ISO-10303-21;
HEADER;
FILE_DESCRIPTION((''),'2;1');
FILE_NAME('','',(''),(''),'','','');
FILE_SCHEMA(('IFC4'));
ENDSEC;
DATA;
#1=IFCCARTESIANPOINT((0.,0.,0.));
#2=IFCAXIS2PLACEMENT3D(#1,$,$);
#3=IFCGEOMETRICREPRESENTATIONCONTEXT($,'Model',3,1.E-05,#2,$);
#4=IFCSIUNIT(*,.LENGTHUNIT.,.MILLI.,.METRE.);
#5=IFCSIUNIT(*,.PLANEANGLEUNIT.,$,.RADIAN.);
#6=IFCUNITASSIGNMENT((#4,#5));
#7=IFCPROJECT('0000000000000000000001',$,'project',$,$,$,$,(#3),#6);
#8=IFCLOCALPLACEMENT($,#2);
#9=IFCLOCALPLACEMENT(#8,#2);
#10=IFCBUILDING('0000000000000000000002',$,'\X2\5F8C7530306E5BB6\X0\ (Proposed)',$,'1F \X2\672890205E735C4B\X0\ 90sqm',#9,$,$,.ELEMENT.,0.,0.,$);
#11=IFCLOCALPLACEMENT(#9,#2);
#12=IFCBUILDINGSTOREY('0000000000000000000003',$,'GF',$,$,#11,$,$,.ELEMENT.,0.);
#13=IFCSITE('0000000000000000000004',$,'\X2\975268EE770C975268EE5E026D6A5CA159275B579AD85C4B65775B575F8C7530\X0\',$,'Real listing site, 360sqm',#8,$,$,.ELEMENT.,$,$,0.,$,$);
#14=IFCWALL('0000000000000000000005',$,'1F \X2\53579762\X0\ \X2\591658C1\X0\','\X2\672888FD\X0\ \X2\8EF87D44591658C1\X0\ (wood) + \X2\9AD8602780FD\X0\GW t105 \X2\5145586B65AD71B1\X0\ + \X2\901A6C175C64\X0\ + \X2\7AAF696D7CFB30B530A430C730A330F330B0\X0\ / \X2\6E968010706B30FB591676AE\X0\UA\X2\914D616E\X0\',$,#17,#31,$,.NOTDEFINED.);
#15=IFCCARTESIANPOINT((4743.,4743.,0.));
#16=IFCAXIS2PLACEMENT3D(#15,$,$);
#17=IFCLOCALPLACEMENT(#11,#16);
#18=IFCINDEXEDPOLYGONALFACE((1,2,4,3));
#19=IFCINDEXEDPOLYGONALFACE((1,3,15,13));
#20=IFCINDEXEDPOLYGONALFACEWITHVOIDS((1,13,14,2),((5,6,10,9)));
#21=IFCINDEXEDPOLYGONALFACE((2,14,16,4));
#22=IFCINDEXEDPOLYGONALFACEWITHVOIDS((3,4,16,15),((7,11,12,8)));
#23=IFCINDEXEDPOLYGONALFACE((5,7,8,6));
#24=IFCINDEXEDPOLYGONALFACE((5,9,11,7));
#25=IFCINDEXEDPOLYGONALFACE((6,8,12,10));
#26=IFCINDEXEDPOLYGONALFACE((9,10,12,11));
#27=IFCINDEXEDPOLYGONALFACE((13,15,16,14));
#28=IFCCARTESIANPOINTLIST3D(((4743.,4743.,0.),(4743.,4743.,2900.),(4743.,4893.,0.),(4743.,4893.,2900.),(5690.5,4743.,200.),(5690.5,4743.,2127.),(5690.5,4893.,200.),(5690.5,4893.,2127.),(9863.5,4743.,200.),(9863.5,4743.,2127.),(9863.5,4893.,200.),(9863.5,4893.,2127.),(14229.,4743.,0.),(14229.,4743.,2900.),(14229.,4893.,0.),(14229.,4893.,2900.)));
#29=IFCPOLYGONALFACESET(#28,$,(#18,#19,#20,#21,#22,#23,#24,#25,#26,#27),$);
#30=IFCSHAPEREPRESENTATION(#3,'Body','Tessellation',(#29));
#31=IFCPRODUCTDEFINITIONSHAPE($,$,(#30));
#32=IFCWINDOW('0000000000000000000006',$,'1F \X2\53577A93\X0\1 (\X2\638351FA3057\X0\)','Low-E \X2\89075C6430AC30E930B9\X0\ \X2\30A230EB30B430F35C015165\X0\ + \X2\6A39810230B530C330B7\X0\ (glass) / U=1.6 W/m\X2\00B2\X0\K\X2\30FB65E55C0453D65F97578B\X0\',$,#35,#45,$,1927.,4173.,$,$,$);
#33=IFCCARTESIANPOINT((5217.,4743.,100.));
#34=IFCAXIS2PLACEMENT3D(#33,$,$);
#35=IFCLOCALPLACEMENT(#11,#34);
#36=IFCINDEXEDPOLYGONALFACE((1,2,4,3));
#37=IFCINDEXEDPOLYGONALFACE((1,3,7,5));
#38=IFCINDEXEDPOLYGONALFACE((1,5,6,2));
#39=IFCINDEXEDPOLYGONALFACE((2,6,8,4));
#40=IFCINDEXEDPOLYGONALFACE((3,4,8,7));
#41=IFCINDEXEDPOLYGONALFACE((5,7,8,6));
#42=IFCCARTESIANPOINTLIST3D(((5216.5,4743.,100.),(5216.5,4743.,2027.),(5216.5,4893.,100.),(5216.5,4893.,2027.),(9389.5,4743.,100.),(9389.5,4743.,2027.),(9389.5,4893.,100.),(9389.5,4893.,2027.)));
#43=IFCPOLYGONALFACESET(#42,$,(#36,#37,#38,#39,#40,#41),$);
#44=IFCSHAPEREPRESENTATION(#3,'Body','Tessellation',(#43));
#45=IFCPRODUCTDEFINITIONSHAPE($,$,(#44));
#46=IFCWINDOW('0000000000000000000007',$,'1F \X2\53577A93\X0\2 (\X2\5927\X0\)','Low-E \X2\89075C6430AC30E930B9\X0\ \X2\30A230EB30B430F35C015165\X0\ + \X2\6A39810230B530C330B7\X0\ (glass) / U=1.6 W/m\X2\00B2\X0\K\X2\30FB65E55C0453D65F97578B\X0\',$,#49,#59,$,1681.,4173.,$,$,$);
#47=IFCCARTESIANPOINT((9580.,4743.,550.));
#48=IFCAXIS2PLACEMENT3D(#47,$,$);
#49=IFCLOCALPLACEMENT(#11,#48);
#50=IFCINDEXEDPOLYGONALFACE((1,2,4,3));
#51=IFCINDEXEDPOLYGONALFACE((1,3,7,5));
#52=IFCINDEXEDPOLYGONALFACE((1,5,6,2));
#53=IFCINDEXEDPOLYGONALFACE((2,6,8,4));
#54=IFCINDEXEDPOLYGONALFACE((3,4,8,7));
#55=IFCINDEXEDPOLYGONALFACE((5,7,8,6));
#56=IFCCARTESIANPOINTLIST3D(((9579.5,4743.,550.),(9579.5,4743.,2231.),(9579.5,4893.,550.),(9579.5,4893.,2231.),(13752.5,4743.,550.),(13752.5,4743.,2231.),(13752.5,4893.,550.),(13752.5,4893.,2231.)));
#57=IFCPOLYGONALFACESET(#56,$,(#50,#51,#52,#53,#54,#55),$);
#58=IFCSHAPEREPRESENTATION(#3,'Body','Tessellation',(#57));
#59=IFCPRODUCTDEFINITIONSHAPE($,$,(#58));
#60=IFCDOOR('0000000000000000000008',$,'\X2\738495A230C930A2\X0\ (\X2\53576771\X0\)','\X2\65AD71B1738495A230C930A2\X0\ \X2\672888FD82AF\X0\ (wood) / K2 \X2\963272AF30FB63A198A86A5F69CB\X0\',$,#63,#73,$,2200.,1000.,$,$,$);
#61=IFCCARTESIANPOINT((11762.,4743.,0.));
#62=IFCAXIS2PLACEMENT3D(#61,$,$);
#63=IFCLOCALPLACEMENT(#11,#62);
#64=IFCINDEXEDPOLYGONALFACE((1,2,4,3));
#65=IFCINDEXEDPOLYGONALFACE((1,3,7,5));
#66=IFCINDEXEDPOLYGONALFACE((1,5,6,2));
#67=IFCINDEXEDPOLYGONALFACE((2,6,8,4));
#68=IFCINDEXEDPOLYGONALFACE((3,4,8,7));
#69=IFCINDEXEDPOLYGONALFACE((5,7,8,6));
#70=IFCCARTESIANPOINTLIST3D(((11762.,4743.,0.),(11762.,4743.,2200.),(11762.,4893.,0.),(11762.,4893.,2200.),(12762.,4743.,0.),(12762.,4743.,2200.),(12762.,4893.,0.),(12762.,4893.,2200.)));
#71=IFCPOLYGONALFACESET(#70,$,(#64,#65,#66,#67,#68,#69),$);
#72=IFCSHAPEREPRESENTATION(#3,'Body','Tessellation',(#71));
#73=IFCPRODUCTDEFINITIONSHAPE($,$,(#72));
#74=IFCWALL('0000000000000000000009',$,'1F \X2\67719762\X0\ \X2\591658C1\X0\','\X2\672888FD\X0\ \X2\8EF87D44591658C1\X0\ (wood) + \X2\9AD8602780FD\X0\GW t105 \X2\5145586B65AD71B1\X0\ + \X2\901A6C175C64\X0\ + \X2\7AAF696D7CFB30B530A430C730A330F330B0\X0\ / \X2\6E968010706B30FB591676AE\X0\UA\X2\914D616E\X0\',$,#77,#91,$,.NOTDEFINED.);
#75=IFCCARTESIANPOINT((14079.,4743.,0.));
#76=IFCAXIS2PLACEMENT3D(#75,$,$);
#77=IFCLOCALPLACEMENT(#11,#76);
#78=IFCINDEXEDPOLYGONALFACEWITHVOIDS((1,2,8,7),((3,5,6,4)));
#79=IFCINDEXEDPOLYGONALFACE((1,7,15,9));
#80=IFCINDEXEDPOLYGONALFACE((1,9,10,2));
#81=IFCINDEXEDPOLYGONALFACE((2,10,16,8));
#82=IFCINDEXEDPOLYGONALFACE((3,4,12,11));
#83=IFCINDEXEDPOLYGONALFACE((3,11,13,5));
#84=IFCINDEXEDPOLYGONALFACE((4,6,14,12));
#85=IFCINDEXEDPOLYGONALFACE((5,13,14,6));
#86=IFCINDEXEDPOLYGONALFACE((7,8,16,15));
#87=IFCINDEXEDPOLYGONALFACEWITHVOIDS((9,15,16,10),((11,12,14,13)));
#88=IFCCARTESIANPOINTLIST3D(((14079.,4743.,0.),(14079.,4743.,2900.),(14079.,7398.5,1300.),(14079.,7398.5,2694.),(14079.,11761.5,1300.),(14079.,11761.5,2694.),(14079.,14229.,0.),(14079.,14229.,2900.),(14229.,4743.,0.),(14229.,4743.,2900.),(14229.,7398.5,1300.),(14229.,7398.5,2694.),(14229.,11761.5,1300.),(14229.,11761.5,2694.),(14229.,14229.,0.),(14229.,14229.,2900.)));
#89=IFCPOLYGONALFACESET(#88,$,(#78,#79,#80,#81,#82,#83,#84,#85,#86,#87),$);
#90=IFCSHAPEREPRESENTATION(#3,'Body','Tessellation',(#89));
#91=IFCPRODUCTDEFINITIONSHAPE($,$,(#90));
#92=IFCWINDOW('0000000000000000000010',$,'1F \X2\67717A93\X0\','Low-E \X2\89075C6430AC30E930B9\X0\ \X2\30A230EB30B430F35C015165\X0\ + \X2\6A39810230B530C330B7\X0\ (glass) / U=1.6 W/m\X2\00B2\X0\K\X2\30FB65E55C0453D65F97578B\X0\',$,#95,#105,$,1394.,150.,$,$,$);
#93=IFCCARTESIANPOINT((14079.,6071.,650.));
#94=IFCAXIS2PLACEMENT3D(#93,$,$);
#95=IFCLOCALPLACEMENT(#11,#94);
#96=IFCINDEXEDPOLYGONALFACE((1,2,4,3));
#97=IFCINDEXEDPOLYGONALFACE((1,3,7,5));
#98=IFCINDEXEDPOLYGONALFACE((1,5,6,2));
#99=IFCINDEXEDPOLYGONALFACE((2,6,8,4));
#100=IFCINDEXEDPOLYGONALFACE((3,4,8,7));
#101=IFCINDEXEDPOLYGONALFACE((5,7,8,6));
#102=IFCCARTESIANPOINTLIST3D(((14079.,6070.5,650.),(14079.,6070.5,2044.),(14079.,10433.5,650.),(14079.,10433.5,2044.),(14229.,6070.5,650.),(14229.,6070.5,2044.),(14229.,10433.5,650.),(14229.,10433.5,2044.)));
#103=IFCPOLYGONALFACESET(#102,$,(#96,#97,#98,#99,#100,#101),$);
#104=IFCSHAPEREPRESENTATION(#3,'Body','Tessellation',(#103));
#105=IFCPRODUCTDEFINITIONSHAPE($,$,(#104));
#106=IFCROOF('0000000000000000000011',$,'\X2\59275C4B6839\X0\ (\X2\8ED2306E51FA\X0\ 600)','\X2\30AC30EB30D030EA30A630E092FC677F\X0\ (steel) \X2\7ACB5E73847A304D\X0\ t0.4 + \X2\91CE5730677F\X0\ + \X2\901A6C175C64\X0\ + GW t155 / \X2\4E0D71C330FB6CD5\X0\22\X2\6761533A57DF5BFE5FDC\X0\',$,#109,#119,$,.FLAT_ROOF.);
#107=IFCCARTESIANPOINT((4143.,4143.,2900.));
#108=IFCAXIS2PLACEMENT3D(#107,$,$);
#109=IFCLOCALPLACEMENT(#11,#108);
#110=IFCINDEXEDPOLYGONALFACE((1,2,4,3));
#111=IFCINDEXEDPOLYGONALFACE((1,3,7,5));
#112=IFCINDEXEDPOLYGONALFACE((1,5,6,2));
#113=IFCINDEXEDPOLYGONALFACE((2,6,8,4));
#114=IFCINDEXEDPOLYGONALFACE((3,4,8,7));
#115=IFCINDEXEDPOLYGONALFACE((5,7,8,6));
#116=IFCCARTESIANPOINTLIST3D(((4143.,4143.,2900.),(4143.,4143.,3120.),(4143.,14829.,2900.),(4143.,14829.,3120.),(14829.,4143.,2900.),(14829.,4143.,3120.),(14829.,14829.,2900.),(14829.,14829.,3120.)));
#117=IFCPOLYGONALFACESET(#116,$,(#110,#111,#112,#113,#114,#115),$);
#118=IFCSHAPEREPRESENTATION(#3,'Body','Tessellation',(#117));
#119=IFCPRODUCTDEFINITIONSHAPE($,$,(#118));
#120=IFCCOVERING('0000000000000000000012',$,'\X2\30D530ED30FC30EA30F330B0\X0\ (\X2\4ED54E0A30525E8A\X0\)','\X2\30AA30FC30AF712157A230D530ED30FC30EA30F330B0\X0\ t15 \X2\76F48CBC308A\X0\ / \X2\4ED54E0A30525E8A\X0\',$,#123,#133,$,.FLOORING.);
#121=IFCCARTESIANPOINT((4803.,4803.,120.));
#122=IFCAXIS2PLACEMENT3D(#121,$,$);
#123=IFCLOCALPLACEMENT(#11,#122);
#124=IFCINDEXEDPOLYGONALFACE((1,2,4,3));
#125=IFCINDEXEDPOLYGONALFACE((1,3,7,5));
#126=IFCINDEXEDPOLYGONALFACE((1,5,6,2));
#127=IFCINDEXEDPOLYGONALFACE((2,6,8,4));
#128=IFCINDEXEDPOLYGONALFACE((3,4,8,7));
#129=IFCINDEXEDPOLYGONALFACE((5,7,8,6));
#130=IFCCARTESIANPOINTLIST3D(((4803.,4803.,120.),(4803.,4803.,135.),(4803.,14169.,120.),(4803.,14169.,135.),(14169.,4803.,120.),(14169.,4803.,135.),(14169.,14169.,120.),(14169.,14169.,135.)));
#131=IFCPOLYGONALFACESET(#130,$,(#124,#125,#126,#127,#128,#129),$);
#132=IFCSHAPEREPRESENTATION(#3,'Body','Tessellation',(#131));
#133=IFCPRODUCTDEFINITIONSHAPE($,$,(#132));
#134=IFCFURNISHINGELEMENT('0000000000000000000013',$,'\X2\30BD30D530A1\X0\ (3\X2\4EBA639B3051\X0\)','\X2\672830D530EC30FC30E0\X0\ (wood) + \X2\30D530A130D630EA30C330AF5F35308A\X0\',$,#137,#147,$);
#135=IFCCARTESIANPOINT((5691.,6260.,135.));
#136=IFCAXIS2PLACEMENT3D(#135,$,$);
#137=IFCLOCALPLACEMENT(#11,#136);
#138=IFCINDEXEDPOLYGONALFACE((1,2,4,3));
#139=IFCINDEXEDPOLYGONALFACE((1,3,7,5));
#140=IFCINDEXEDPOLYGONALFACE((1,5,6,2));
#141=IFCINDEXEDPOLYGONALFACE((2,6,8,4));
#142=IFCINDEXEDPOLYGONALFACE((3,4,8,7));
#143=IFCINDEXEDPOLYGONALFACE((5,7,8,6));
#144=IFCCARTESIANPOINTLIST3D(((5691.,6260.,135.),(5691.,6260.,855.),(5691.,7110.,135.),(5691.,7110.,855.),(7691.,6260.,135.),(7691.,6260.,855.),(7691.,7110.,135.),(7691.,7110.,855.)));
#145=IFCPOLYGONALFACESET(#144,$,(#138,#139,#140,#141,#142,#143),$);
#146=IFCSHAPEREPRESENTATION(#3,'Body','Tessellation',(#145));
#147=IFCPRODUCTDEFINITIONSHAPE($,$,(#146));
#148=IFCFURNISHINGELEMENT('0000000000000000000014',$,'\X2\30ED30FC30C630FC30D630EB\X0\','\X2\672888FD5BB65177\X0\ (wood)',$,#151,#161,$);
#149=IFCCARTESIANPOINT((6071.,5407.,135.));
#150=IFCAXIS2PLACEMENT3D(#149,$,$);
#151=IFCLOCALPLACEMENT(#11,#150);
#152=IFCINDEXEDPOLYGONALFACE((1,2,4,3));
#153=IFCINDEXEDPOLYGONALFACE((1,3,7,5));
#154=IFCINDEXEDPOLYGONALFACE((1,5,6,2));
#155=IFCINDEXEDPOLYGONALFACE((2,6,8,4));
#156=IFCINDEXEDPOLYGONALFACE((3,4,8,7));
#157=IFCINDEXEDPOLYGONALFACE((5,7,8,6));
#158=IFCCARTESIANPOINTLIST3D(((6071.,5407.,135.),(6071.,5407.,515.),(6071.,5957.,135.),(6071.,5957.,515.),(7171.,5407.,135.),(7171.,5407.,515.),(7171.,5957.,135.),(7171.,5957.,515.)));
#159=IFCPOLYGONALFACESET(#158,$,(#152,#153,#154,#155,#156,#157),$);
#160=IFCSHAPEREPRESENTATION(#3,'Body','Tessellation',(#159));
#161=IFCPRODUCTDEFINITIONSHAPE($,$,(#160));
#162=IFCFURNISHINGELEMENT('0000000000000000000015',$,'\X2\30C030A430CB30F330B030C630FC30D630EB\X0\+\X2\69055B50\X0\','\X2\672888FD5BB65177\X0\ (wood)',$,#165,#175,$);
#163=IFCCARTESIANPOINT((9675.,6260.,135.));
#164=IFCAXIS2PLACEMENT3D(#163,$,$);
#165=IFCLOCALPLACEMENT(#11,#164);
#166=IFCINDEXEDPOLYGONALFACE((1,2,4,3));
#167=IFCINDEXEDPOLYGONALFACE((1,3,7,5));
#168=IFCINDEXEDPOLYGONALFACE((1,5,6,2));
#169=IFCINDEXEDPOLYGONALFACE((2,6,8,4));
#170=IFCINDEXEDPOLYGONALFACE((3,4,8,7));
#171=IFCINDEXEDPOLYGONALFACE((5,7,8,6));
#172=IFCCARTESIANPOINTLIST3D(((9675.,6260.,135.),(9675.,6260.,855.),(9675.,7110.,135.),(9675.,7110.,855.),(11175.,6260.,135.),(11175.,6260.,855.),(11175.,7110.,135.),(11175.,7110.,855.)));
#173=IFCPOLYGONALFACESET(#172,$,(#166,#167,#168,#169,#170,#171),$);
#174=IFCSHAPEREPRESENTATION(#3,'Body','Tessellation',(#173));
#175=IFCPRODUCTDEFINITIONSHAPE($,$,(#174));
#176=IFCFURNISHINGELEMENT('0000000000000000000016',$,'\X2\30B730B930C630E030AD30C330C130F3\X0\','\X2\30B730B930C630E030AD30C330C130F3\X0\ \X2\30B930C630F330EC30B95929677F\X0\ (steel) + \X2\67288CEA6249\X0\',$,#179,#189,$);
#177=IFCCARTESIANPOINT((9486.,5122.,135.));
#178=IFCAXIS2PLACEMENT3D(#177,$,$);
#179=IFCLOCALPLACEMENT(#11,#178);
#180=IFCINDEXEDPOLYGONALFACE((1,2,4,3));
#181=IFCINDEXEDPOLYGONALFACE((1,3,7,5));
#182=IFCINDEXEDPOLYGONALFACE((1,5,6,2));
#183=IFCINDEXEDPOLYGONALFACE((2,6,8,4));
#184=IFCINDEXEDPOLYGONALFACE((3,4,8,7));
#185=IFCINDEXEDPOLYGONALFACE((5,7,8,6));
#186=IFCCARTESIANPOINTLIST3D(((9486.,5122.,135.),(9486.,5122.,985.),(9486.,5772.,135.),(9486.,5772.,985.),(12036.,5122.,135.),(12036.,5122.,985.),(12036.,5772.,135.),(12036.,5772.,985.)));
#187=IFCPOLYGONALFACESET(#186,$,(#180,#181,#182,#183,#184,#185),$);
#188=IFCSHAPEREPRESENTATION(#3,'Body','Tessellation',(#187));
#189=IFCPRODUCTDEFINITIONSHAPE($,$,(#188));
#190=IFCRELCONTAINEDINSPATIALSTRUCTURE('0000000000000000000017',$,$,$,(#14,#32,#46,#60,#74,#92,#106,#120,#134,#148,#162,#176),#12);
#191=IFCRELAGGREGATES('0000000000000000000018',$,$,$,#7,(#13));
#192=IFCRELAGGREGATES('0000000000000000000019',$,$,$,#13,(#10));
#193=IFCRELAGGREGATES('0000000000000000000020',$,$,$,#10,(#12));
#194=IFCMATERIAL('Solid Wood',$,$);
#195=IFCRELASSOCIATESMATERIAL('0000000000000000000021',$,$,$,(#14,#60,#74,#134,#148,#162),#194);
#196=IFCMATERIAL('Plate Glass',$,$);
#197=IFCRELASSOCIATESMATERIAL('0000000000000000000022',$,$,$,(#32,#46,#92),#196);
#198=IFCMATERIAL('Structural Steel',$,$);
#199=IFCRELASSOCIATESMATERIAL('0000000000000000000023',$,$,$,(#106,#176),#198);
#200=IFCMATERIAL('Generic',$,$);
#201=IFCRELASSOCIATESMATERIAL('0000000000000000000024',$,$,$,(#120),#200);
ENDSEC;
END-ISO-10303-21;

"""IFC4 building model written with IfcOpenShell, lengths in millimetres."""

from ifc_helpers import new_model, si_unit, frame, frame_2d, origin, place, context, project, spatial, rectangle, extrude, material, element, fill, save


model = new_model("IFC4")

# Units and contexts
model_context = context("Model", 3, precision=1e-05, world=origin())
ifc_project = project(units=[si_unit("LENGTHUNIT", "METRE", prefix="MILLI"), si_unit("PLANEANGLEUNIT", "RADIAN")], contexts=[model_context])

# Site, building, storey
site_placement = place(None, origin())
site = spatial("IfcSite", under=ifc_project, at=site_placement, Name="青森県青森市浪岡大字高屋敷字後田", ObjectType="Real listing site, 360sqm", CompositionType="ELEMENT", RefElevation=0.0)
building_placement = place(site_placement, origin())
building = spatial("IfcBuilding", under=site, at=building_placement, Name="後田の家 (Proposed)", ObjectType="1F 木造平屋 90sqm", CompositionType="ELEMENT", ElevationOfRefHeight=0.0, ElevationOfTerrain=0.0)
storey_placement = place(building_placement, origin())
storey = spatial("IfcBuildingStorey", under=building, at=storey_placement, Name="GF", CompositionType="ELEMENT", Elevation=0.0)

# Shared definitions
ifc_material_1 = material(Name="Solid Wood")

# Wall, openings, windows, door
wall_1_placement = place(storey_placement, frame((4743.0, 4743.0, 0.0)))
wall_1 = element("IfcWall", 1, at=wall_1_placement, inside=storey, material=ifc_material_1, Name="1F 南面 外壁", Description="木製 軸組外壁 (wood) + 高性能GW t105 充填断熱 + 通気層 + 窯業系サイディング / 準耐火・外皮UA配慮", PredefinedType="NOTDEFINED", context=model_context, shape_type="SweptSolid", body=[
    extrude(rectangle(XDim=9486.0, YDim=150.0, at=frame_2d((4743.0, 75.0))), frame((4743.0, 4743.0, 0.0)), (0.0, 0.0, 1.0), 2900.0),
])
opening_1_placement = place(storey_placement, frame((5217.0, 4743.0, 100.0)))
opening_1 = element("IfcOpeningElement", 2, at=opening_1_placement, cuts=wall_1, PredefinedType="NOTDEFINED", context=model_context, shape_type="SweptSolid", body=[
    extrude(rectangle(XDim=4173.0, YDim=150.0, at=frame_2d((2086.0, 75.0))), frame((5217.0, 4743.0, 100.0)), (0.0, 0.0, 1.0), 1927.0),
])
opening_2_placement = place(storey_placement, frame((9580.0, 4743.0, 550.0)))
opening_2 = element("IfcOpeningElement", 3, at=opening_2_placement, cuts=wall_1, PredefinedType="NOTDEFINED", context=model_context, shape_type="SweptSolid", body=[
    extrude(rectangle(XDim=4173.0, YDim=150.0, at=frame_2d((2086.0, 75.0))), frame((9580.0, 4743.0, 550.0)), (0.0, 0.0, 1.0), 1681.0),
])
opening_3_placement = place(storey_placement, frame((11762.0, 4743.0, 0.0)))
opening_3 = element("IfcOpeningElement", 4, at=opening_3_placement, cuts=wall_1, PredefinedType="NOTDEFINED", context=model_context, shape_type="SweptSolid", body=[
    extrude(rectangle(XDim=1000.0, YDim=150.0, at=frame_2d((500.0, 75.0))), frame((11762.0, 4743.0, 0.0)), (0.0, 0.0, 1.0), 2200.0),
])
ifc_material_2 = material(Name="Plate Glass")
window_1_placement = place(storey_placement, frame((5217.0, 4743.0, 100.0)))
window_1 = element("IfcWindow", 5, at=window_1_placement, inside=storey, material=ifc_material_2, Name="1F 南窓1 (掃出し)", Description="Low-E 複層ガラス アルゴン封入 + 樹脂サッシ (glass) / U=1.6 W/m²K・日射取得型", OverallHeight=1927.0, OverallWidth=4173.0, context=model_context, shape_type="SweptSolid", body=[
    extrude(rectangle(XDim=4173.0, YDim=150.0, at=frame_2d((2086.0, 75.0))), frame((5217.0, 4743.0, 100.0)), (0.0, 0.0, 1.0), 1927.0),
])
fill(opening_1, window_1)
window_2_placement = place(storey_placement, frame((9580.0, 4743.0, 550.0)))
window_2 = element("IfcWindow", 6, at=window_2_placement, inside=storey, material=ifc_material_2, Name="1F 南窓2 (大)", Description="Low-E 複層ガラス アルゴン封入 + 樹脂サッシ (glass) / U=1.6 W/m²K・日射取得型", OverallHeight=1681.0, OverallWidth=4173.0, context=model_context, shape_type="SweptSolid", body=[
    extrude(rectangle(XDim=4173.0, YDim=150.0, at=frame_2d((2086.0, 75.0))), frame((9580.0, 4743.0, 550.0)), (0.0, 0.0, 1.0), 1681.0),
])
fill(opening_2, window_2)
door_placement = place(storey_placement, frame((11762.0, 4743.0, 0.0)))
door = element("IfcDoor", 7, at=door_placement, inside=storey, material=ifc_material_1, Name="玄関ドア (南東)", Description="断熱玄関ドア 木製芯 (wood) / K2 防犯・採風機構", OverallHeight=2200.0, OverallWidth=1000.0, context=model_context, shape_type="SweptSolid", body=[
    extrude(rectangle(XDim=1000.0, YDim=150.0, at=frame_2d((500.0, 75.0))), frame((11762.0, 4743.0, 0.0)), (0.0, 0.0, 1.0), 2200.0),
])
fill(opening_3, door)

# Wall, opening, window
wall_2_placement = place(storey_placement, frame((14079.0, 4743.0, 0.0)))
wall_2 = element("IfcWall", 8, at=wall_2_placement, inside=storey, material=ifc_material_1, Name="1F 東面 外壁", Description="木製 軸組外壁 (wood) + 高性能GW t105 充填断熱 + 通気層 + 窯業系サイディング / 準耐火・外皮UA配慮", PredefinedType="NOTDEFINED", context=model_context, shape_type="SweptSolid", body=[
    extrude(rectangle(XDim=150.0, YDim=9486.0, at=frame_2d((75.0, 4743.0))), frame((14079.0, 4743.0, 0.0)), (0.0, 0.0, 1.0), 2900.0),
])
opening_4_placement = place(storey_placement, frame((14079.0, 6071.0, 650.0)))
opening_4 = element("IfcOpeningElement", 9, at=opening_4_placement, cuts=wall_2, PredefinedType="NOTDEFINED", context=model_context, shape_type="SweptSolid", body=[
    extrude(rectangle(XDim=150.0, YDim=4363.0, at=frame_2d((75.0, 2181.0))), frame((14079.0, 6071.0, 650.0)), (0.0, 0.0, 1.0), 1394.0),
])
window_3_placement = place(storey_placement, frame((14079.0, 6071.0, 650.0)))
window_3 = element("IfcWindow", 10, at=window_3_placement, inside=storey, material=ifc_material_2, Name="1F 東窓", Description="Low-E 複層ガラス アルゴン封入 + 樹脂サッシ (glass) / U=1.6 W/m²K・日射取得型", OverallHeight=1394.0, OverallWidth=150.0, context=model_context, shape_type="SweptSolid", body=[
    extrude(rectangle(XDim=150.0, YDim=4363.0, at=frame_2d((75.0, 2181.0))), frame((14079.0, 6071.0, 650.0)), (0.0, 0.0, 1.0), 1394.0),
])
fill(opening_4, window_3)

# Roof
ifc_material_3 = material(Name="Structural Steel")
roof_placement = place(storey_placement, frame((4143.0, 4143.0, 2900.0)))
element("IfcRoof", 11, at=roof_placement, inside=storey, material=ifc_material_3, Name="大屋根 (軒の出 600)", Description="ガルバリウム鋼板 (steel) 立平葺き t0.4 + 野地板 + 通気層 + GW t155 / 不燃・法22条区域対応", PredefinedType="FLAT_ROOF", context=model_context, shape_type="SweptSolid", body=[
    extrude(rectangle(XDim=10686.0, YDim=10686.0, at=frame_2d((5343.0, 5343.0))), frame((4143.0, 4143.0, 2900.0)), (0.0, 0.0, 1.0), 220.0),
])

# Covering
ifc_material_4 = material(Name="Generic")
covering_placement = place(storey_placement, frame((4803.0, 4803.0, 120.0)))
element("IfcCovering", 12, at=covering_placement, inside=storey, material=ifc_material_4, Name="フローリング (仕上げ床)", Description="オーク無垢フローリング t15 直貼り / 仕上げ床", PredefinedType="FLOORING", context=model_context, shape_type="SweptSolid", body=[
    extrude(rectangle(XDim=9366.0, YDim=9366.0, at=frame_2d((4683.0, 4683.0))), frame((4803.0, 4803.0, 120.0)), (0.0, 0.0, 1.0), 15.0),
])

# Furnishing elements
furnishing_1_placement = place(storey_placement, frame((5691.0, 6260.0, 135.0)))
element("IfcFurnishingElement", 13, at=furnishing_1_placement, inside=storey, material=ifc_material_1, Name="ソファ (3人掛け)", Description="木フレーム (wood) + ファブリック張り", context=model_context, shape_type="SweptSolid", body=[
    extrude(rectangle(XDim=2000.0, YDim=850.0, at=frame_2d((1000.0, 425.0))), frame((5691.0, 6260.0, 135.0)), (0.0, 0.0, 1.0), 720.0),
])
furnishing_2_placement = place(storey_placement, frame((6071.0, 5407.0, 135.0)))
element("IfcFurnishingElement", 14, at=furnishing_2_placement, inside=storey, material=ifc_material_1, Name="ローテーブル", Description="木製家具 (wood)", context=model_context, shape_type="SweptSolid", body=[
    extrude(rectangle(XDim=1100.0, YDim=550.0, at=frame_2d((550.0, 275.0))), frame((6071.0, 5407.0, 135.0)), (0.0, 0.0, 1.0), 380.0),
])
furnishing_3_placement = place(storey_placement, frame((9675.0, 6260.0, 135.0)))
element("IfcFurnishingElement", 15, at=furnishing_3_placement, inside=storey, material=ifc_material_1, Name="ダイニングテーブル+椅子", Description="木製家具 (wood)", context=model_context, shape_type="SweptSolid", body=[
    extrude(rectangle(XDim=1500.0, YDim=850.0, at=frame_2d((750.0, 425.0))), frame((9675.0, 6260.0, 135.0)), (0.0, 0.0, 1.0), 720.0),
])
furnishing_4_placement = place(storey_placement, frame((9486.0, 5122.0, 135.0)))
element("IfcFurnishingElement", 16, at=furnishing_4_placement, inside=storey, material=ifc_material_3, Name="システムキッチン", Description="システムキッチン ステンレス天板 (steel) + 木質扉", context=model_context, shape_type="SweptSolid", body=[
    extrude(rectangle(XDim=2550.0, YDim=650.0, at=frame_2d((1275.0, 325.0))), frame((9486.0, 5122.0, 135.0)), (0.0, 0.0, 1.0), 850.0),
])

save(model, "model.ifc")
